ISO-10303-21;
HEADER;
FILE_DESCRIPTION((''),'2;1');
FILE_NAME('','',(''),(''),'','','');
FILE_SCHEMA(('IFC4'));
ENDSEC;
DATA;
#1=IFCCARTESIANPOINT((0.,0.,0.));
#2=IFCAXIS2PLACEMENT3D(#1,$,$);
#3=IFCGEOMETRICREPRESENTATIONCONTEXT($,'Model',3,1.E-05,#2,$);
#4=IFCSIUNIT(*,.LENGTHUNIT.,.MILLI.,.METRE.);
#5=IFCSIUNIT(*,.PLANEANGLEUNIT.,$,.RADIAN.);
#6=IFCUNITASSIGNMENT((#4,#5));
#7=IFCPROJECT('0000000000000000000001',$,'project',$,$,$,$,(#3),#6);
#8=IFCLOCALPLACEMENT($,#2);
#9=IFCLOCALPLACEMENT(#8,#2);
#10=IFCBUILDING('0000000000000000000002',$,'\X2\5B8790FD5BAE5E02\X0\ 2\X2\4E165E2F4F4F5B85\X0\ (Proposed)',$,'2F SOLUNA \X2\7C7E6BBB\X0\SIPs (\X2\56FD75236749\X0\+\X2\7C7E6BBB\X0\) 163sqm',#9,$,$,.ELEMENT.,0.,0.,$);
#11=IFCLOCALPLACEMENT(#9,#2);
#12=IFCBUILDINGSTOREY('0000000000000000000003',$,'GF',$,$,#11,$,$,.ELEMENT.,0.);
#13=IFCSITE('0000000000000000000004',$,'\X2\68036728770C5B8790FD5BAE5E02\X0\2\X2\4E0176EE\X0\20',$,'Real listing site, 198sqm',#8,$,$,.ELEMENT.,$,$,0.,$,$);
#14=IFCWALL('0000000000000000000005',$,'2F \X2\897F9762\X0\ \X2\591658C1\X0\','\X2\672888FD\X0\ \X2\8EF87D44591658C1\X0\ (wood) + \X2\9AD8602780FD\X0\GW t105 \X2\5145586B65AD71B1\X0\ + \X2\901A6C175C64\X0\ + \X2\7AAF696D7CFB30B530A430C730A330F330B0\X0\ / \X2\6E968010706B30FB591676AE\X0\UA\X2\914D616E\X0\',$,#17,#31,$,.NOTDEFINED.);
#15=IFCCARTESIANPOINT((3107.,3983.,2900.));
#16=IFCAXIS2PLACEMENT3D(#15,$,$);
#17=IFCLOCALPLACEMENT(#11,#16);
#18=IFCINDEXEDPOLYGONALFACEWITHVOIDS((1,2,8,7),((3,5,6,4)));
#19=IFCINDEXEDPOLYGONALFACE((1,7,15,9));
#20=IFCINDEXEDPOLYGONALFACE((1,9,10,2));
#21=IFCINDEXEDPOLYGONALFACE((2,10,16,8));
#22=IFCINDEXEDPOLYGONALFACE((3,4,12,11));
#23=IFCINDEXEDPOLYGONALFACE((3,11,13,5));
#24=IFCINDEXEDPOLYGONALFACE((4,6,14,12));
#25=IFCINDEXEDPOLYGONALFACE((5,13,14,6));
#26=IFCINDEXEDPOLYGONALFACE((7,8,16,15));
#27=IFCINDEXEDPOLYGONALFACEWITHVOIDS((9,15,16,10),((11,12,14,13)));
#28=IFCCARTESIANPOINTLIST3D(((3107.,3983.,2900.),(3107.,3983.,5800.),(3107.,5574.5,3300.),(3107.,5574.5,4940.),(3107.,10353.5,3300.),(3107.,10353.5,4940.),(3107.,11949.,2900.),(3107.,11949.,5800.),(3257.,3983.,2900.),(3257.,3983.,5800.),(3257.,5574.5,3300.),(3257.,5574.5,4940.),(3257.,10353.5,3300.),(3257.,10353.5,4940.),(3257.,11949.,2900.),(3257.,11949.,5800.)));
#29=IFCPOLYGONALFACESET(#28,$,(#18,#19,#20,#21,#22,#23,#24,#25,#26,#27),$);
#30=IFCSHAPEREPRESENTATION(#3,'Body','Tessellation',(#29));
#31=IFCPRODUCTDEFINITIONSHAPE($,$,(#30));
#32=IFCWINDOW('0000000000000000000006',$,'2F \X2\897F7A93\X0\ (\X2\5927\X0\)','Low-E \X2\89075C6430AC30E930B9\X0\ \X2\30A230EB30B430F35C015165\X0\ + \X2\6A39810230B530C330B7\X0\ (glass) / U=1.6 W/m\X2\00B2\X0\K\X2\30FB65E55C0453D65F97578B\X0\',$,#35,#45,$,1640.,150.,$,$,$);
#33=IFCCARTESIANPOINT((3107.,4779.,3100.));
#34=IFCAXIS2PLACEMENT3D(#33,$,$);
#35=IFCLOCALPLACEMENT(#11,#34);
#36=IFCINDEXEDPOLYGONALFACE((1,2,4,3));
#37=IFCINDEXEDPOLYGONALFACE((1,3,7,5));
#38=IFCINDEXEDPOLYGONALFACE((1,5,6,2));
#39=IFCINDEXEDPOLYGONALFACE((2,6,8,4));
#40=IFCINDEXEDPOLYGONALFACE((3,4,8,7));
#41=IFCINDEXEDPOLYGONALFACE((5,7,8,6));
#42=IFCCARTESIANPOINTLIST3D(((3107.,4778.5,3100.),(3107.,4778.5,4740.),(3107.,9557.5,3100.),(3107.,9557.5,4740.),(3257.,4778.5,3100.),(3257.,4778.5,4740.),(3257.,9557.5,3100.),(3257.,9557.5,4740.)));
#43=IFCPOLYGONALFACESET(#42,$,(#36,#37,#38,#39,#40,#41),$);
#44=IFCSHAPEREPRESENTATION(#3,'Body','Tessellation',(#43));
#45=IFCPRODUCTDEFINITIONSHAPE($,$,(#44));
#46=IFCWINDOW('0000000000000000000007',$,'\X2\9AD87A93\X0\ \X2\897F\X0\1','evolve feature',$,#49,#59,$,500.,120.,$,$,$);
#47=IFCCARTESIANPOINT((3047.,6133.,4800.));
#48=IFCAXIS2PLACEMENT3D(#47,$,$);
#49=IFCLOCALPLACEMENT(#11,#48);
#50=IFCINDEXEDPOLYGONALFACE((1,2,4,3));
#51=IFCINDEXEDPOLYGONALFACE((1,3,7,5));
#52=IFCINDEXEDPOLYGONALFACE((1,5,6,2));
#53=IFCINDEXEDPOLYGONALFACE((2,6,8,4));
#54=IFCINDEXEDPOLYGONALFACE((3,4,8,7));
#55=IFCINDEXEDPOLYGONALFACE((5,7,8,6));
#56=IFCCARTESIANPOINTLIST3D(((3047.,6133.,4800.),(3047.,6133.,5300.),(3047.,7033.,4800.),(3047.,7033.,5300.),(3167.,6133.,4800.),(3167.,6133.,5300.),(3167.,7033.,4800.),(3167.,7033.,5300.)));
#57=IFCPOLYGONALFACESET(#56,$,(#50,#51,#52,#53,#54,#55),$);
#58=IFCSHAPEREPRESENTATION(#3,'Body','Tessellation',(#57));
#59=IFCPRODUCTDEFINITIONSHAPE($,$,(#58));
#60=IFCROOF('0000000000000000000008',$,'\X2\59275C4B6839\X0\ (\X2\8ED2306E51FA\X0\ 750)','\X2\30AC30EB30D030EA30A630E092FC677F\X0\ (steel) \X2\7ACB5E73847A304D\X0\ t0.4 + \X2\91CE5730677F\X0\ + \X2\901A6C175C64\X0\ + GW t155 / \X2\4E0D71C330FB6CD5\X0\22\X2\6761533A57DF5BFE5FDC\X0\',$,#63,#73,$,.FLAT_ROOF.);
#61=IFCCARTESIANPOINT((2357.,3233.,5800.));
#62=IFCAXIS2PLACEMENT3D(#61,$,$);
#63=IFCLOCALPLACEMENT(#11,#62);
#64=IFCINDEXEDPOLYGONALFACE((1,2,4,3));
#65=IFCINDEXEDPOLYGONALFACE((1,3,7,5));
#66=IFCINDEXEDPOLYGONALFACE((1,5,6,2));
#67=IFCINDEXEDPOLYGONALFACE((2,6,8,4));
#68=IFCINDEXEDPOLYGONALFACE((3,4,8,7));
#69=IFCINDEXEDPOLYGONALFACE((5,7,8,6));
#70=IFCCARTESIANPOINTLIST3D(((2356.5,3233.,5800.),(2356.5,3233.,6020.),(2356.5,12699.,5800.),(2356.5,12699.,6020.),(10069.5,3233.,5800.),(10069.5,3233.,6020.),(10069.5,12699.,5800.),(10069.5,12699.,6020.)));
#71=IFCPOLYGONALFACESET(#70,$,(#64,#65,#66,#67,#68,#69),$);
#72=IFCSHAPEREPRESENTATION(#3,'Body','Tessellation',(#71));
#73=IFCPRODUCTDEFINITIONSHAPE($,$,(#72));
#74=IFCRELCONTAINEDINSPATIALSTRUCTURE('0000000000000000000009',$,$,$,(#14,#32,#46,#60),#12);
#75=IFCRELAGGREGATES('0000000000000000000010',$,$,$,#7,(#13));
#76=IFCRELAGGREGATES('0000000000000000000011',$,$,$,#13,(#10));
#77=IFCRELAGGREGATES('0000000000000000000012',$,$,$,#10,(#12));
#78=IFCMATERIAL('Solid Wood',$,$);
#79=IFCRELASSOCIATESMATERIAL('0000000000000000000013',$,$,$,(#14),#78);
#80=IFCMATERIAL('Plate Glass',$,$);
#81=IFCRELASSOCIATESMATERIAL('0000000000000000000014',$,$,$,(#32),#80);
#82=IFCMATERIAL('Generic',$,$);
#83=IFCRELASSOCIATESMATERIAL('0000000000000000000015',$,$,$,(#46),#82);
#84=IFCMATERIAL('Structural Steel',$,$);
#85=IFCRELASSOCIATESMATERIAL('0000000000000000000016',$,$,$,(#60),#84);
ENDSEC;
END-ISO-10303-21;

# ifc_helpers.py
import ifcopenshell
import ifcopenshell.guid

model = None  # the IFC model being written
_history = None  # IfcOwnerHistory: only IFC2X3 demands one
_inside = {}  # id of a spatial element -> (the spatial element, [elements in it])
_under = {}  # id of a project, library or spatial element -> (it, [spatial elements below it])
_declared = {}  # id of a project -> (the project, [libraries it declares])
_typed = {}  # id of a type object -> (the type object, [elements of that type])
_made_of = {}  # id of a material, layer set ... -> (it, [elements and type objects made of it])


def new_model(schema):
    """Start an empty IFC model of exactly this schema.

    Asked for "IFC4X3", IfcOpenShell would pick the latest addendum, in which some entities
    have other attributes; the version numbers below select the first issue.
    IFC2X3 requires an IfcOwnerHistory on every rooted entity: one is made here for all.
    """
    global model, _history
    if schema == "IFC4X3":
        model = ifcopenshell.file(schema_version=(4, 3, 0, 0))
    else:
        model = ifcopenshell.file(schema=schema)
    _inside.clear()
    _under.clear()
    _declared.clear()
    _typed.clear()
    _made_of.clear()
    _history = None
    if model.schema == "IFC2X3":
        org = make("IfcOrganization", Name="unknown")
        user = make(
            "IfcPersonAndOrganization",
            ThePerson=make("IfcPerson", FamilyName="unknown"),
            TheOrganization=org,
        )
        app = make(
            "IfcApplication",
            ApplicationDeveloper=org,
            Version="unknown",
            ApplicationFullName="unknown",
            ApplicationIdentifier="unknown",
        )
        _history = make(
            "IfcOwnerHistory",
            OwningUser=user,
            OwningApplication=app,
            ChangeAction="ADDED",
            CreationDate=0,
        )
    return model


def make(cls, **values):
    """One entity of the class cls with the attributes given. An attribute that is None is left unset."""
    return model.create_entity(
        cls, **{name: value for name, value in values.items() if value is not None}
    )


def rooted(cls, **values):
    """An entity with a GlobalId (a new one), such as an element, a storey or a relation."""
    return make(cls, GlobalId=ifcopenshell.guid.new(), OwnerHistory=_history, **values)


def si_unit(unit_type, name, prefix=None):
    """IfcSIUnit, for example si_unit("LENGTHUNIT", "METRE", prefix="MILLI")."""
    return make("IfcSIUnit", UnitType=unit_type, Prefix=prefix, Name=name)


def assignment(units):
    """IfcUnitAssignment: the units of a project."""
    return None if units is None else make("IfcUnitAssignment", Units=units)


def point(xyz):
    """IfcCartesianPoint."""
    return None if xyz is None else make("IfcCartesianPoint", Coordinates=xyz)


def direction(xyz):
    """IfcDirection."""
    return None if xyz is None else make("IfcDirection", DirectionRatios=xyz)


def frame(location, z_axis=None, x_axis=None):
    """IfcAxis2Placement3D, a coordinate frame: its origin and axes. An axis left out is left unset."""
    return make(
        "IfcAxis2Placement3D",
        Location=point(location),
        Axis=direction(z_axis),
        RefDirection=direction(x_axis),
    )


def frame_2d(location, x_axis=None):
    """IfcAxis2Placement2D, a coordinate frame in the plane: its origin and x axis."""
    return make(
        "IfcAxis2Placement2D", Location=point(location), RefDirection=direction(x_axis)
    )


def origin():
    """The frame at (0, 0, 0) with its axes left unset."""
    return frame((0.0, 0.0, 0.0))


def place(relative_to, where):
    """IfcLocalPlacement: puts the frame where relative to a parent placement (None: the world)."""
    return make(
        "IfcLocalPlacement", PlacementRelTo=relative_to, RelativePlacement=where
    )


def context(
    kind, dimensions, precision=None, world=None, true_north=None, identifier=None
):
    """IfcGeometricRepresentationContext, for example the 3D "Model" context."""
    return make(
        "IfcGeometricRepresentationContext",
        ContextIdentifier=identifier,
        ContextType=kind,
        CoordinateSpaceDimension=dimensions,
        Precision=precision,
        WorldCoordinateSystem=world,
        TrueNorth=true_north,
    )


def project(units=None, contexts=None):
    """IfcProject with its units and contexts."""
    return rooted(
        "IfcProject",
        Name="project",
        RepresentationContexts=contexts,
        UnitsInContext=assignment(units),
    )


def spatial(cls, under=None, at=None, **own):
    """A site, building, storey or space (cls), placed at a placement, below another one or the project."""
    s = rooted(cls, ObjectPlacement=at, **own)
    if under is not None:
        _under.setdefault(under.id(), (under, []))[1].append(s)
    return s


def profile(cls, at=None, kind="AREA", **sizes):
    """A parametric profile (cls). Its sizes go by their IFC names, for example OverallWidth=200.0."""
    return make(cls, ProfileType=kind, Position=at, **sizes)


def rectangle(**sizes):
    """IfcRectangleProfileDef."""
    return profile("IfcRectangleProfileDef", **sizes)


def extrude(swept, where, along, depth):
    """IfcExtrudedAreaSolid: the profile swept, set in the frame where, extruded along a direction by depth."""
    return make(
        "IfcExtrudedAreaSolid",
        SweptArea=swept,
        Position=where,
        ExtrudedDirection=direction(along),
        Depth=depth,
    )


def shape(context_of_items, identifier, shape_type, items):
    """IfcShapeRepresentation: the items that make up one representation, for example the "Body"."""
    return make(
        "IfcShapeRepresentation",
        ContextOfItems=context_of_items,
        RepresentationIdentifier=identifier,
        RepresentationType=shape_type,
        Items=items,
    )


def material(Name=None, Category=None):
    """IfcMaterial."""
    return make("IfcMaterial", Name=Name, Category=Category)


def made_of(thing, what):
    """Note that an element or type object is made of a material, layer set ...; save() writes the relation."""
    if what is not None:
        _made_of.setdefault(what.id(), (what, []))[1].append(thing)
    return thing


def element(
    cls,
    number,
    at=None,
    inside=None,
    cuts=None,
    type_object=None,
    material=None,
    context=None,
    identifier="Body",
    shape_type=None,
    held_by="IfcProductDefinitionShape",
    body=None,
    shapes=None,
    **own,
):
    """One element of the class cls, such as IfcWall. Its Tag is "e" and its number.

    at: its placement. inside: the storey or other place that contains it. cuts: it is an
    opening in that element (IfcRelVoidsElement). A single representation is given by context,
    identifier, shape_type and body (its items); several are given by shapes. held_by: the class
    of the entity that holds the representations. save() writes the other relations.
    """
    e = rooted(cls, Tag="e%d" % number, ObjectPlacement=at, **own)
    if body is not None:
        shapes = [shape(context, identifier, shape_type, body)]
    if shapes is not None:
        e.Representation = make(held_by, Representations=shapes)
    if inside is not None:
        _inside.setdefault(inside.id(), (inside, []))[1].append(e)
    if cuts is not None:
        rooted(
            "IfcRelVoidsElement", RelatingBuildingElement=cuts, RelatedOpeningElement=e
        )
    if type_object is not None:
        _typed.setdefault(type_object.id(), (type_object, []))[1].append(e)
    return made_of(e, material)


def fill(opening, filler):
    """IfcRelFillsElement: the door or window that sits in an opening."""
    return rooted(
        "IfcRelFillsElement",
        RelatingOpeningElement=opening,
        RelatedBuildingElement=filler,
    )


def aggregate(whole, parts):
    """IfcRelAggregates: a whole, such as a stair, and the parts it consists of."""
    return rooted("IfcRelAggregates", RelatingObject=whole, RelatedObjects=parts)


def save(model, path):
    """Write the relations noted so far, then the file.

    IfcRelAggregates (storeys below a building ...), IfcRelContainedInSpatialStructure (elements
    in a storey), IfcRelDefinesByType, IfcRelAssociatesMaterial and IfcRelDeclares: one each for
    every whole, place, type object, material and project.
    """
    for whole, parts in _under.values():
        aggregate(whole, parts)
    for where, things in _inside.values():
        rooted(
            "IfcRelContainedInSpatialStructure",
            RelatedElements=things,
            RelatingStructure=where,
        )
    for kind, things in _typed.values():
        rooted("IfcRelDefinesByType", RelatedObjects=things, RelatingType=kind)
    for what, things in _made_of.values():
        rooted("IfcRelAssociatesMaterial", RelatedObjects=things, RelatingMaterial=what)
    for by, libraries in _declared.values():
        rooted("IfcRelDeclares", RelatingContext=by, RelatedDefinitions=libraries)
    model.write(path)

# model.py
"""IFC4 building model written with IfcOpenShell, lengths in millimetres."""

from ifc_helpers import new_model, si_unit, frame, frame_2d, origin, place, context, project, spatial, rectangle, extrude, material, element, fill, save


model = new_model("IFC4")

# Units and contexts
model_context = context("Model", 3, precision=1e-05, world=origin())
ifc_project = project(units=[si_unit("LENGTHUNIT", "METRE", prefix="MILLI"), si_unit("PLANEANGLEUNIT", "RADIAN")], contexts=[model_context])

# Site, building, storey
site_placement = place(None, origin())
site = spatial("IfcSite", under=ifc_project, at=site_placement, Name="栃木県宇都宮市2丁目20", ObjectType="Real listing site, 198sqm", CompositionType="ELEMENT", RefElevation=0.0)
building_placement = place(site_placement, origin())
building = spatial("IfcBuilding", under=site, at=building_placement, Name="宇都宮市 2世帯住宅 (Proposed)", ObjectType="2F SOLUNA 籾殻SIPs (国産杉+籾殻) 163sqm", CompositionType="ELEMENT", ElevationOfRefHeight=0.0, ElevationOfTerrain=0.0)
storey_placement = place(building_placement, origin())
storey = spatial("IfcBuildingStorey", under=building, at=storey_placement, Name="GF", CompositionType="ELEMENT", Elevation=0.0)

# Shared definitions
ifc_material_1 = material(Name="Solid Wood")
ifc_material_2 = material(Name="Generic")

# Shared definitions
ifc_material_3 = material(Name="Plate Glass")

# Wall, openings, windows
wall_1_placement = place(storey_placement, frame((3107.0, 3983.0, 2900.0)))
wall_1 = element("IfcWall", 1, at=wall_1_placement, inside=storey, material=ifc_material_1, Name="2F 西面 外壁", Description="木製 軸組外壁 (wood) + 高性能GW t105 充填断熱 + 通気層 + 窯業系サイディング / 準耐火・外皮UA配慮", PredefinedType="NOTDEFINED", context=model_context, shape_type="SweptSolid", body=[
    extrude(rectangle(XDim=150.0, YDim=7966.0, at=frame_2d((75.0, 3983.0))), frame((3107.0, 3983.0, 2900.0)), (0.0, 0.0, 1.0), 2900.0),
])
opening_1_placement = place(storey_placement, frame((3107.0, 4779.0, 3100.0)))
opening_1 = element("IfcOpeningElement", 2, at=opening_1_placement, cuts=wall_1, PredefinedType="NOTDEFINED", context=model_context, shape_type="SweptSolid", body=[
    extrude(rectangle(XDim=150.0, YDim=4779.0, at=frame_2d((75.0, 2389.0))), frame((3107.0, 4779.0, 3100.0)), (0.0, 0.0, 1.0), 1640.0),
])
opening_2_placement = place(storey_placement, frame((3047.0, 6133.0, 4800.0)))
opening_2 = element("IfcOpeningElement", 3, at=opening_2_placement, cuts=wall_1, PredefinedType="NOTDEFINED", context=model_context, shape_type="SweptSolid", body=[
    extrude(rectangle(XDim=120.0, YDim=900.0, at=frame_2d((60.0, 450.0))), frame((3047.0, 6133.0, 4800.0)), (0.0, 0.0, 1.0), 500.0),
])
window_1_placement = place(storey_placement, frame((3107.0, 4779.0, 3100.0)))
window_1 = element("IfcWindow", 4, at=window_1_placement, inside=storey, material=ifc_material_3, Name="2F 西窓 (大)", Description="Low-E 複層ガラス アルゴン封入 + 樹脂サッシ (glass) / U=1.6 W/m²K・日射取得型", OverallHeight=1640.0, OverallWidth=150.0, context=model_context, shape_type="SweptSolid", body=[
    extrude(rectangle(XDim=150.0, YDim=4779.0, at=frame_2d((75.0, 2389.0))), frame((3107.0, 4779.0, 3100.0)), (0.0, 0.0, 1.0), 1640.0),
])
fill(opening_1, window_1)
window_2_placement = place(storey_placement, frame((3047.0, 6133.0, 4800.0)))
window_2 = element("IfcWindow", 5, at=window_2_placement, inside=storey, material=ifc_material_2, Name="高窓 西1", Description="evolve feature", OverallHeight=500.0, OverallWidth=120.0, context=model_context, shape_type="SweptSolid", body=[
    extrude(rectangle(XDim=120.0, YDim=900.0, at=frame_2d((60.0, 450.0))), frame((3047.0, 6133.0, 4800.0)), (0.0, 0.0, 1.0), 500.0),
])
fill(opening_2, window_2)

# Roof
ifc_material_4 = material(Name="Structural Steel")
roof_1_placement = place(storey_placement, frame((2357.0, 3233.0, 5800.0)))
element("IfcRoof", 6, at=roof_1_placement, inside=storey, material=ifc_material_4, Name="大屋根 (軒の出 750)", Description="ガルバリウム鋼板 (steel) 立平葺き t0.4 + 野地板 + 通気層 + GW t155 / 不燃・法22条区域対応", PredefinedType="FLAT_ROOF", context=model_context, shape_type="SweptSolid", body=[
    extrude(rectangle(XDim=7713.0, YDim=9466.0, at=frame_2d((3856.0, 4733.0))), frame((2357.0, 3233.0, 5800.0)), (0.0, 0.0, 1.0), 220.0),
])

save(model, "model.ifc")
